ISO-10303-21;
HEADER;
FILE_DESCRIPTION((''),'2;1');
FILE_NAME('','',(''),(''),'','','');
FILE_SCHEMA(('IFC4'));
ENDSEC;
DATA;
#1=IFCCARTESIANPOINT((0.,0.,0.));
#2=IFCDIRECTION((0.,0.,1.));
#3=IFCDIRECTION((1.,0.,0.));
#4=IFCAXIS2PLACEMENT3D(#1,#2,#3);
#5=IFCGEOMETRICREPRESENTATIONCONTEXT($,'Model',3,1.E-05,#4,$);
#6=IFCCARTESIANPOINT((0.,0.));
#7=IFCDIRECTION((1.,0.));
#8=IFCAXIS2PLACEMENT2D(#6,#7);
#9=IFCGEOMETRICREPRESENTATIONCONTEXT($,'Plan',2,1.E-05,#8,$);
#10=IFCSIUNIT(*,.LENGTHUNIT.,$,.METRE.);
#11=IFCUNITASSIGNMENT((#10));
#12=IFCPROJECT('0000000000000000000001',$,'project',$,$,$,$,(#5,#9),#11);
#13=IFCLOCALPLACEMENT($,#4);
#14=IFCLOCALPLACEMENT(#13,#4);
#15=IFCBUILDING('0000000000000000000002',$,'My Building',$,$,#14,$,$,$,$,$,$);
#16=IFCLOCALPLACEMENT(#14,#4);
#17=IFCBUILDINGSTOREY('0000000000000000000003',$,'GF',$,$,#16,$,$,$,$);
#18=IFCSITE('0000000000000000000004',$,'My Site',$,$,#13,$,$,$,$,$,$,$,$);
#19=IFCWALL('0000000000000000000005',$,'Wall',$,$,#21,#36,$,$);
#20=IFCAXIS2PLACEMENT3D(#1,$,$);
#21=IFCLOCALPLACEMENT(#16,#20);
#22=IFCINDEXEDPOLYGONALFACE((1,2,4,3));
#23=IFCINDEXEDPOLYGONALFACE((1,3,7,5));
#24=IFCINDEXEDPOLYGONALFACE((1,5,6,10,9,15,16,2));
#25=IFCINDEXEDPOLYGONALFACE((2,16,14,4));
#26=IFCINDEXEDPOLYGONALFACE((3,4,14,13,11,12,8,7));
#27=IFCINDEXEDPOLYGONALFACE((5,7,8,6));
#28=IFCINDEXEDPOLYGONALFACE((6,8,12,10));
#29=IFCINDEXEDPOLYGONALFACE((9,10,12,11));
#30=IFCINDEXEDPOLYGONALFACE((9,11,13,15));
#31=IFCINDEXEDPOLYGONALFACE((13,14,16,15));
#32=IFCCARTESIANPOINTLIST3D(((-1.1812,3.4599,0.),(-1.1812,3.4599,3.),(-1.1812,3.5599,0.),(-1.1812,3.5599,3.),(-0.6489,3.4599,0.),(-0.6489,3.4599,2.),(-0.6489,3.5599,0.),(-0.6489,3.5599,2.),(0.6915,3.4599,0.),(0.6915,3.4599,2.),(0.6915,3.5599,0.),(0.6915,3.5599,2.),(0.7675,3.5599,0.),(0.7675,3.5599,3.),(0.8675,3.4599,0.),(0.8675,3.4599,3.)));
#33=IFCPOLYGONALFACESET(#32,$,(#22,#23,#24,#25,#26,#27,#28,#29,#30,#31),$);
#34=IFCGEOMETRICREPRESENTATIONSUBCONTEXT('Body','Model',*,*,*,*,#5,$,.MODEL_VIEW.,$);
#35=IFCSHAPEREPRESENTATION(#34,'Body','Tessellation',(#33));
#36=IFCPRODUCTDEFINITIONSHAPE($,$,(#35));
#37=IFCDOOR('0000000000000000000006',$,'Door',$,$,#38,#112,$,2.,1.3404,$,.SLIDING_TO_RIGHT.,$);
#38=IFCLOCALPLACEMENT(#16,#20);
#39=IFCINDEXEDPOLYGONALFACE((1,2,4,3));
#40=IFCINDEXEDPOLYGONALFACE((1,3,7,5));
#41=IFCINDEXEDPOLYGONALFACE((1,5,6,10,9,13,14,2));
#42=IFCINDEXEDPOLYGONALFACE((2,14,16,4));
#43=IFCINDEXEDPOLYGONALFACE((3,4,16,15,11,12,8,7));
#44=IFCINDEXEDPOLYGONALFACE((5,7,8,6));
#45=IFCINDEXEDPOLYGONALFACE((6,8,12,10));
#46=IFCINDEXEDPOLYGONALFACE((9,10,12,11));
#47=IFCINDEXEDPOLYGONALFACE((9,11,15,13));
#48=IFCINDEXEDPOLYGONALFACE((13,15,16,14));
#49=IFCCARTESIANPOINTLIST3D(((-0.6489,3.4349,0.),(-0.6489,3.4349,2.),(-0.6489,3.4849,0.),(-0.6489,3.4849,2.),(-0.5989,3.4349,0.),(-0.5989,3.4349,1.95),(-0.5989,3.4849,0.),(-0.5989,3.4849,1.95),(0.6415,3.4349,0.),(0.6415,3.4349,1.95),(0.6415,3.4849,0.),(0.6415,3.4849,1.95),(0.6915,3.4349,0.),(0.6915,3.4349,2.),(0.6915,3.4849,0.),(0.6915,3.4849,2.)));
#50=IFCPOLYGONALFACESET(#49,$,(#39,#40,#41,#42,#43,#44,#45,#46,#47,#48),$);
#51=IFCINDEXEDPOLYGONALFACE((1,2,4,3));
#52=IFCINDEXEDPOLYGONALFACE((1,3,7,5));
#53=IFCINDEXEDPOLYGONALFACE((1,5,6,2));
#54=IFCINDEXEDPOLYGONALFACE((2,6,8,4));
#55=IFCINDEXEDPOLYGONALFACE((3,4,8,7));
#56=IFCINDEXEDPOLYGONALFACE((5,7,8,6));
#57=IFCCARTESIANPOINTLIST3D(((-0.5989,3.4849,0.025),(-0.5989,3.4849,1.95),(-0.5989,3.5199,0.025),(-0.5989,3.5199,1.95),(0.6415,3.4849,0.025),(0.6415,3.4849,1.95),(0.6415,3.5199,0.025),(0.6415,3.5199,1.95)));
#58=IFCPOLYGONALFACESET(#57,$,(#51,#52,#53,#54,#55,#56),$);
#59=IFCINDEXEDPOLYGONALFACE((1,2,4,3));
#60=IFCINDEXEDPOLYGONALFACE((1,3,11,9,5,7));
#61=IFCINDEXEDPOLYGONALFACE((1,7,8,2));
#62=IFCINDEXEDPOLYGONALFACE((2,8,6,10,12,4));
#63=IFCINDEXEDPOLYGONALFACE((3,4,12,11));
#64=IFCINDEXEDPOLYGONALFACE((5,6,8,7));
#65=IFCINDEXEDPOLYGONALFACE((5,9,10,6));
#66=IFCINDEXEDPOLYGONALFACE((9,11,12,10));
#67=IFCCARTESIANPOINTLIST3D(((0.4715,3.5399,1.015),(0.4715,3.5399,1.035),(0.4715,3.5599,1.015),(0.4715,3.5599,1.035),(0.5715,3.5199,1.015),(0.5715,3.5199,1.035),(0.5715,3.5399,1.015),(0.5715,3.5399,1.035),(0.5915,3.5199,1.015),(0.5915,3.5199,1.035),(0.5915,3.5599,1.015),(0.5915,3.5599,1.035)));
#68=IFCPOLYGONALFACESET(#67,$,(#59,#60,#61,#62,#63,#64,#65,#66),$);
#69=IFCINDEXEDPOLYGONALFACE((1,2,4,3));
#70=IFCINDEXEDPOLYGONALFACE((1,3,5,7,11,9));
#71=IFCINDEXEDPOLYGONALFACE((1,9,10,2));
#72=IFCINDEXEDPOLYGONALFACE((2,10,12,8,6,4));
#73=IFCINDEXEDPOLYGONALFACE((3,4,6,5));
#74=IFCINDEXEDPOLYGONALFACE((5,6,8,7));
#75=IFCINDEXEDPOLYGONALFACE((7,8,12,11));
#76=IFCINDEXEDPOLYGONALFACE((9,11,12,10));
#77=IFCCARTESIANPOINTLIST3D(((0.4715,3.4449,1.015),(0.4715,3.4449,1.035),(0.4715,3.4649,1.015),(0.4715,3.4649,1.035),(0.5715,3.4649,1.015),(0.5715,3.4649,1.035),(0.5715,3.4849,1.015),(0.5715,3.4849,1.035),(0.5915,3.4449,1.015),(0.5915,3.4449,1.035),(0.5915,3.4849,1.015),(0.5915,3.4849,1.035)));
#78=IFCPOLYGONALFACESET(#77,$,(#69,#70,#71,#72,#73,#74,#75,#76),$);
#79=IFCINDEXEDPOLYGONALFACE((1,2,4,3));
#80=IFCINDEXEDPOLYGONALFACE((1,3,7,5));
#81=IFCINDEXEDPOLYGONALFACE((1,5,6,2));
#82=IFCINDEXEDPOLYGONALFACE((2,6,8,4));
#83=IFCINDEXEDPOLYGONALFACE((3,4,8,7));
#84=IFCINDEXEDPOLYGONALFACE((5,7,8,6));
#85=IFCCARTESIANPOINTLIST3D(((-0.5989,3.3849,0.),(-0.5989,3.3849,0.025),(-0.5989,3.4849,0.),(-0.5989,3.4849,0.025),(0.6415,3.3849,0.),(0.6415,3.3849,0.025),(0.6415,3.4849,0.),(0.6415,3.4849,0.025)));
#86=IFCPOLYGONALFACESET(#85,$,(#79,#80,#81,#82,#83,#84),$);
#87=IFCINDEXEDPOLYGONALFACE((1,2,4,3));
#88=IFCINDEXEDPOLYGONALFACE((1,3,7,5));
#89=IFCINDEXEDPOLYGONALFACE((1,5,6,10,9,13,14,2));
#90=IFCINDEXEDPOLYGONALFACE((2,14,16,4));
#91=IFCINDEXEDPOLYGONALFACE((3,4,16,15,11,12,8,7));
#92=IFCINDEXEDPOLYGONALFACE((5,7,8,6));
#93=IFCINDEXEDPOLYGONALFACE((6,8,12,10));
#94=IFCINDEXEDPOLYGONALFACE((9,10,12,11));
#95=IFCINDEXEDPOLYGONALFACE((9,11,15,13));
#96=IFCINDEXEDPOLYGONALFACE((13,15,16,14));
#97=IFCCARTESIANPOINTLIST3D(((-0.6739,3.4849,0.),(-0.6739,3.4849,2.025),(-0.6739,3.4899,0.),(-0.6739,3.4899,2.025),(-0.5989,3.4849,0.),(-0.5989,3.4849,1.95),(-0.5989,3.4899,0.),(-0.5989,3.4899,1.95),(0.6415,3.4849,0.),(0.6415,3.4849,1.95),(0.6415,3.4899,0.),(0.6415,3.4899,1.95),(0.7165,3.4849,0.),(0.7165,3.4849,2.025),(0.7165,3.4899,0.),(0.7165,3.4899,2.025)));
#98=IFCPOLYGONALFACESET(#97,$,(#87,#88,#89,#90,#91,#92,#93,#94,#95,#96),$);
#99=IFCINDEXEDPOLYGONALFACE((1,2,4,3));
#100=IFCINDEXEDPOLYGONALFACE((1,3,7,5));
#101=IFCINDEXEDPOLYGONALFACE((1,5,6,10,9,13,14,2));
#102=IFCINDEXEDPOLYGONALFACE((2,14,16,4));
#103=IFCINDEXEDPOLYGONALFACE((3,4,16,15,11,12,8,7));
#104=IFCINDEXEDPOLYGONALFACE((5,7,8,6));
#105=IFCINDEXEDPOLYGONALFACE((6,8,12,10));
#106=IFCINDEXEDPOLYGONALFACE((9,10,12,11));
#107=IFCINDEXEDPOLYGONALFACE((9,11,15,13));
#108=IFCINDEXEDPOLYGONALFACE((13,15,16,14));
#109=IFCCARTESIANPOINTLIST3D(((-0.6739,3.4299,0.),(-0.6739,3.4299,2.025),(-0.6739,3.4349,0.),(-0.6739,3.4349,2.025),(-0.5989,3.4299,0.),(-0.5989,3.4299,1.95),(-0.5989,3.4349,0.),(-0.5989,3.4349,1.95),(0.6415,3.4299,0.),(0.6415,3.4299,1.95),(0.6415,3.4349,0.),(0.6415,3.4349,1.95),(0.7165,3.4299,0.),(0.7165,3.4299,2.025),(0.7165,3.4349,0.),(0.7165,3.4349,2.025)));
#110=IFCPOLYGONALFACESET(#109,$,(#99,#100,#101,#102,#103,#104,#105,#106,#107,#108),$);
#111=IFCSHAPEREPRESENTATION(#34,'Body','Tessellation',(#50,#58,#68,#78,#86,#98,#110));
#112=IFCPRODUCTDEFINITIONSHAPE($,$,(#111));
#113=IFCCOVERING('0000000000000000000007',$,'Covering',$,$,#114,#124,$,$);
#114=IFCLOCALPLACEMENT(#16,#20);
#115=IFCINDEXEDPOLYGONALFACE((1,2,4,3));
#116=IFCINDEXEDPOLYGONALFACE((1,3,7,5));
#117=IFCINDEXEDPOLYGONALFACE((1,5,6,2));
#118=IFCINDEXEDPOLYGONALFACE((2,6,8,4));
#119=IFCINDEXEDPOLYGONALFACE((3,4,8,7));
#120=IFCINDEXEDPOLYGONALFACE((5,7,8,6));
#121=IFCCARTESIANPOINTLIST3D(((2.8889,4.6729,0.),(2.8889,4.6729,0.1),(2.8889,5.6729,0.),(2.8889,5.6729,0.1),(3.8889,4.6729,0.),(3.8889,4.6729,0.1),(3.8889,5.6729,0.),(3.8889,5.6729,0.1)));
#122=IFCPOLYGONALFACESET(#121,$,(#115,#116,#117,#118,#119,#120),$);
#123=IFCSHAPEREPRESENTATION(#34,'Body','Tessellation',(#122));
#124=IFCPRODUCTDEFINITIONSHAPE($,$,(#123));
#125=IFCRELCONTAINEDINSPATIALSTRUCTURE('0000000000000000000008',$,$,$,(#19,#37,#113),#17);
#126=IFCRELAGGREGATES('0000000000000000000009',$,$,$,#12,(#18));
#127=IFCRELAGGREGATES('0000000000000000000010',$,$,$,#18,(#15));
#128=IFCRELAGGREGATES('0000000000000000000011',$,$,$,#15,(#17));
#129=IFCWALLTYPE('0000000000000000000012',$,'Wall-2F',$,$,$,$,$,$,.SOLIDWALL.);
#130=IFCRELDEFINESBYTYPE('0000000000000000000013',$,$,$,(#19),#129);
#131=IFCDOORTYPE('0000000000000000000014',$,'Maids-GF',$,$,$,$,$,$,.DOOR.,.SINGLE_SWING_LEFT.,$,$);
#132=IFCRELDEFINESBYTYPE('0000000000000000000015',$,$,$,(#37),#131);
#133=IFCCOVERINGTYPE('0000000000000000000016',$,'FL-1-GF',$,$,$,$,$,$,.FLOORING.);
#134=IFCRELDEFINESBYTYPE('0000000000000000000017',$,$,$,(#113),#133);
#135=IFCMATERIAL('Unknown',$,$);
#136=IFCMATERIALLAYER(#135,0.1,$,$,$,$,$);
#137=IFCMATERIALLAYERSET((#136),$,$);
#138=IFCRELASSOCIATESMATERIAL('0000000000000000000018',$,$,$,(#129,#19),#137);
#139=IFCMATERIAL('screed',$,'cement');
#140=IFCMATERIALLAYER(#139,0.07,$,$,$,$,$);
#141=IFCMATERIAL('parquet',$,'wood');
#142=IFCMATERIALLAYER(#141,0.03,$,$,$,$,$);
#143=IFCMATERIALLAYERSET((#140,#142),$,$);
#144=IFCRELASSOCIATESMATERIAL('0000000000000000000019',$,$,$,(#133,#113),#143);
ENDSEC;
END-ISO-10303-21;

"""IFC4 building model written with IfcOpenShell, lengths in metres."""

from ifc_helpers import new_model, entity, si_unit, frame, origin_with_axes, origin_2d_with_axis, place, context, subcontext, project, spatial, line, indexed_curve, outline, extrude, shape, source, transform, mapped, material, layer, layer_set, layer_usage, type_object, type_shapes, element, fill, save


model = new_model("IFC4")

# Units and contexts
model_context = context("Model", 3, precision=1e-05, world=origin_with_axes())
plan_context = context("Plan", 2, precision=1e-05, world=origin_2d_with_axis())
body_context_1 = subcontext(model_context, "Body", "Model", "MODEL_VIEW")
body_context_2 = subcontext(plan_context, "Body", "Plan", "PLAN_VIEW")
ifc_project = project(units=[si_unit("LENGTHUNIT", "METRE")], contexts=[model_context, plan_context])

# Site, building, storey
site_placement = place(None, origin_with_axes())
site = spatial("IfcSite", under=ifc_project, at=site_placement, Name="My Site")
building_placement = place(site_placement, origin_with_axes())
building = spatial("IfcBuilding", under=site, at=building_placement, Name="My Building")
storey_placement = place(building_placement, origin_with_axes())
storey = spatial("IfcBuildingStorey", under=building, at=storey_placement, Name="GF")

# Shared definitions
ifc_material_1 = material(Name="Unknown")

# Shared definitions
ifc_layer_1 = layer(ifc_material_1, 0.1)
ifc_layer_set_1 = layer_set([ifc_layer_1])
wall_type = type_object("IfcWallType", Name="Wall-2F", PredefinedType="SOLIDWALL", material=ifc_layer_set_1)

# Wall, opening, door
ifc_layer_usage_1 = layer_usage(ifc_layer_set_1, "AXIS2", "POSITIVE", 0.0)
wall_1_placement = place(storey_placement, frame((0.7675, 3.5599, 0.0), z_axis=(0.0, 0.0, 1.0), x_axis=(-1.0, 0.0, 0.0)))
wall_1 = element("IfcWall", 1, at=wall_1_placement, inside=storey, type_object=wall_type, material=ifc_layer_usage_1, Name="Wall", context=body_context_1, shape_type="SweptSolid", body=[
    extrude(outline(indexed_curve([(0.0, 0.0), (-0.1, 0.1), (1.9486, 0.1), (1.9486, 0.0)], segments=[line(1, 2, 3, 4, 1)])), origin_with_axes(), (0.0, 0.0, 1.0), 3.0),
])
shared_shape_1 = source(origin_with_axes(), body_context_1, "Body", "SweptSolid", [
    extrude(outline(indexed_curve([(0.0, 0.0), (1.3404, 0.0), (1.3404, 2.0), (0.0, 2.0)], segments=[line(1, 2, 3, 4, 1)])), frame((0.0, -0.6, 0.0), z_axis=(0.0, -1.0, 0.0), x_axis=(1.0, 0.0, 0.0)), (0.0, 0.0, -1.0), 1.2),
])
opening_1_placement = place(wall_1_placement, frame((0.076, 0.075, 0.0), z_axis=(0.0, 0.0, 1.0), x_axis=(1.0, -0.000001, 0.0)))
opening_1 = element("IfcOpeningElement", 2, at=opening_1_placement, cuts=wall_1, PredefinedType="OPENING", context=body_context_1, shape_type="MappedRepresentation", body=[
    mapped(shared_shape_1, transform((0.0, 0.0, 0.0), x_axis=(1.0, 0.0, 0.0), y_axis=(0.0, 1.0, 0.0), z_axis=(0.0, 0.0, 1.0), scale=1.0)),
])
door_type_1 = type_object("IfcDoorType", Name="Maids-GF", OperationType="SINGLE_SWING_LEFT", PredefinedType="DOOR")
shared_shape_2 = source(origin_with_axes(), body_context_1, "Body", "SweptSolid", [
    extrude(outline(indexed_curve([(0.0, 0.0), (0.0, 2.0), (1.3404, 2.0), (1.3404, 0.0), (1.2904, 0.0), (1.2904, 1.95), (0.05, 1.95), (0.05, 0.0)], segments=[line(1, 2, 3, 4, 5, 6, 7, 8, 1)])), frame((0.0, 0.0, 0.0), z_axis=(0.0, -1.0, 0.0), x_axis=(1.0, 0.0, 0.0)), (0.0, 0.0, -1.0), 0.05),
    extrude(outline(indexed_curve([(0.0, 0.0), (1.2404, 0.0), (1.2404, 0.035), (0.0, 0.035)], segments=[line(1, 2, 3, 4, 1)])), frame((0.05, -0.035, 0.025), z_axis=(0.0, 0.0, 1.0), x_axis=(1.0, 0.0, 0.0)), (0.0, 0.0, 1.0), 1.925),
    extrude(outline(indexed_curve([(0.0, 0.0), (0.0, -0.04), (0.12, -0.04), (0.12, -0.02), (0.02, -0.02), (0.02, 0.0)], segments=[line(1, 2, 3, 4, 5, 6, 1)])), frame((0.1, -0.035, 1.015), z_axis=(0.0, 0.0, 1.0), x_axis=(1.0, 0.0, 0.0)), (0.0, 0.0, 1.0), 0.02),
    extrude(outline(indexed_curve([(0.0, 0.0), (0.0, 0.04), (0.12, 0.04), (0.12, 0.02), (0.02, 0.02), (0.02, 0.0)], segments=[line(1, 2, 3, 4, 5, 6, 1)])), frame((0.1, 0.0, 1.015), z_axis=(0.0, 0.0, 1.0), x_axis=(1.0, 0.0, 0.0)), (0.0, 0.0, 1.0), 0.02),
    extrude(outline(indexed_curve([(0.0, 0.0), (1.2404, 0.0), (1.2404, 0.1), (0.0, 0.1)], segments=[line(1, 2, 3, 4, 1)])), frame((0.05, 0.0, 0.0), z_axis=(0.0, 0.0, 1.0), x_axis=(1.0, 0.0, 0.0)), (0.0, 0.0, 1.0), 0.025),
    extrude(outline(indexed_curve([(0.0, 0.0), (0.0, 2.025), (1.3904, 2.025), (1.3904, 0.0), (1.3154, 0.0), (1.3154, 1.95), (0.075, 1.95), (0.075, 0.0)], segments=[line(1, 2, 3, 4, 5, 6, 7, 8, 1)])), frame((-0.025, -0.005, 0.0), z_axis=(0.0, -1.0, 0.0), x_axis=(1.0, 0.0, 0.0)), (0.0, 0.0, -1.0), 0.005),
    extrude(outline(indexed_curve([(0.0, 0.0), (0.0, 2.025), (1.3904, 2.025), (1.3904, 0.0), (1.3154, 0.0), (1.3154, 1.95), (0.075, 1.95), (0.075, 0.0)], segments=[line(1, 2, 3, 4, 5, 6, 7, 8, 1)])), frame((-0.025, 0.05, 0.0), z_axis=(0.0, -1.0, 0.0), x_axis=(1.0, 0.0, 0.0)), (0.0, 0.0, -1.0), 0.005),
])
shared_shape_3 = source(origin_with_axes(), body_context_2, "Body", "Curve2D", [
    entity("IfcIndexedPolyCurve", entity("IfcCartesianPointList2D", [[0.0, 0.0], [0.05, 0.0], [0.05, 0.05], [0.0, 0.05]]), [entity("IfcLineIndex", [1, 2, 3, 4, 1])]),
    entity("IfcIndexedPolyCurve", entity("IfcCartesianPointList2D", [[1.3404, 0.0], [1.2904, 0.0], [1.2904, 0.05], [1.3404, 0.05]]), [entity("IfcLineIndex", [1, 2, 3, 4, 1])]),
    entity("IfcIndexedPolyCurve", entity("IfcCartesianPointList2D", [[1.9106, -0.035], [0.6702, -0.035], [0.6702, 0.0], [1.9106, 0.0]]), [entity("IfcLineIndex", [1, 2, 3, 4, 1])]),
])
type_shapes(door_type_1, [shared_shape_2, shared_shape_3])
door_1_placement = place(opening_1_placement, frame((0.0, 0.0, 0.0), z_axis=(0.0, 0.0, 1.0), x_axis=(1.0, 0.0, 0.0)))
door_1 = element("IfcDoor", 3, at=door_1_placement, inside=storey, type_object=door_type_1, Name="Door", OperationType="SLIDING_TO_RIGHT", OverallHeight=2.0, OverallWidth=1.3404, shapes=[
    shape(body_context_1, "Body", "MappedRepresentation", [mapped(shared_shape_2, transform((0.0, 0.0, 0.0), x_axis=(1.0, 0.0, 0.0), y_axis=(0.0, 1.0, 0.0), z_axis=(0.0, 0.0, 1.0), scale=1.0))]),
    shape(body_context_2, "Body", "MappedRepresentation", [mapped(shared_shape_3, transform((0.0, 0.0, 0.0), x_axis=(1.0, 0.0, 0.0), y_axis=(0.0, 1.0, 0.0), z_axis=(0.0, 0.0, 1.0), scale=1.0))]),
])
fill(opening_1, door_1)

# Covering
ifc_material_2 = material(Name="screed", Category="cement")
ifc_layer_2 = layer(ifc_material_2, 0.07)
ifc_material_3 = material(Name="parquet", Category="wood")
ifc_layer_3 = layer(ifc_material_3, 0.03)
ifc_layer_set_2 = layer_set([ifc_layer_2, ifc_layer_3])
ifc_layer_usage_2 = layer_usage(ifc_layer_set_2, "AXIS3", "POSITIVE", 0.0)
covering_type = type_object("IfcCoveringType", Name="FL-1-GF", PredefinedType="FLOORING", material=ifc_layer_set_2)
covering_placement = place(storey_placement, frame((2.8889, 4.6729, 0.0), z_axis=(0.0, 0.0, 1.0), x_axis=(1.0, 0.0, 0.0)))
element("IfcCovering", 4, at=covering_placement, inside=storey, type_object=covering_type, material=ifc_layer_usage_2, Name="Covering", context=body_context_1, shape_type="SweptSolid", body=[
    extrude(outline(indexed_curve([(0.0, 0.0), (1.0, 0.0), (1.0, 1.0), (0.0, 1.0), (0.0, 0.0)])), origin_with_axes(), (0.0, 0.0, 1.0), 0.1),
])

save(model, "model.ifc")
